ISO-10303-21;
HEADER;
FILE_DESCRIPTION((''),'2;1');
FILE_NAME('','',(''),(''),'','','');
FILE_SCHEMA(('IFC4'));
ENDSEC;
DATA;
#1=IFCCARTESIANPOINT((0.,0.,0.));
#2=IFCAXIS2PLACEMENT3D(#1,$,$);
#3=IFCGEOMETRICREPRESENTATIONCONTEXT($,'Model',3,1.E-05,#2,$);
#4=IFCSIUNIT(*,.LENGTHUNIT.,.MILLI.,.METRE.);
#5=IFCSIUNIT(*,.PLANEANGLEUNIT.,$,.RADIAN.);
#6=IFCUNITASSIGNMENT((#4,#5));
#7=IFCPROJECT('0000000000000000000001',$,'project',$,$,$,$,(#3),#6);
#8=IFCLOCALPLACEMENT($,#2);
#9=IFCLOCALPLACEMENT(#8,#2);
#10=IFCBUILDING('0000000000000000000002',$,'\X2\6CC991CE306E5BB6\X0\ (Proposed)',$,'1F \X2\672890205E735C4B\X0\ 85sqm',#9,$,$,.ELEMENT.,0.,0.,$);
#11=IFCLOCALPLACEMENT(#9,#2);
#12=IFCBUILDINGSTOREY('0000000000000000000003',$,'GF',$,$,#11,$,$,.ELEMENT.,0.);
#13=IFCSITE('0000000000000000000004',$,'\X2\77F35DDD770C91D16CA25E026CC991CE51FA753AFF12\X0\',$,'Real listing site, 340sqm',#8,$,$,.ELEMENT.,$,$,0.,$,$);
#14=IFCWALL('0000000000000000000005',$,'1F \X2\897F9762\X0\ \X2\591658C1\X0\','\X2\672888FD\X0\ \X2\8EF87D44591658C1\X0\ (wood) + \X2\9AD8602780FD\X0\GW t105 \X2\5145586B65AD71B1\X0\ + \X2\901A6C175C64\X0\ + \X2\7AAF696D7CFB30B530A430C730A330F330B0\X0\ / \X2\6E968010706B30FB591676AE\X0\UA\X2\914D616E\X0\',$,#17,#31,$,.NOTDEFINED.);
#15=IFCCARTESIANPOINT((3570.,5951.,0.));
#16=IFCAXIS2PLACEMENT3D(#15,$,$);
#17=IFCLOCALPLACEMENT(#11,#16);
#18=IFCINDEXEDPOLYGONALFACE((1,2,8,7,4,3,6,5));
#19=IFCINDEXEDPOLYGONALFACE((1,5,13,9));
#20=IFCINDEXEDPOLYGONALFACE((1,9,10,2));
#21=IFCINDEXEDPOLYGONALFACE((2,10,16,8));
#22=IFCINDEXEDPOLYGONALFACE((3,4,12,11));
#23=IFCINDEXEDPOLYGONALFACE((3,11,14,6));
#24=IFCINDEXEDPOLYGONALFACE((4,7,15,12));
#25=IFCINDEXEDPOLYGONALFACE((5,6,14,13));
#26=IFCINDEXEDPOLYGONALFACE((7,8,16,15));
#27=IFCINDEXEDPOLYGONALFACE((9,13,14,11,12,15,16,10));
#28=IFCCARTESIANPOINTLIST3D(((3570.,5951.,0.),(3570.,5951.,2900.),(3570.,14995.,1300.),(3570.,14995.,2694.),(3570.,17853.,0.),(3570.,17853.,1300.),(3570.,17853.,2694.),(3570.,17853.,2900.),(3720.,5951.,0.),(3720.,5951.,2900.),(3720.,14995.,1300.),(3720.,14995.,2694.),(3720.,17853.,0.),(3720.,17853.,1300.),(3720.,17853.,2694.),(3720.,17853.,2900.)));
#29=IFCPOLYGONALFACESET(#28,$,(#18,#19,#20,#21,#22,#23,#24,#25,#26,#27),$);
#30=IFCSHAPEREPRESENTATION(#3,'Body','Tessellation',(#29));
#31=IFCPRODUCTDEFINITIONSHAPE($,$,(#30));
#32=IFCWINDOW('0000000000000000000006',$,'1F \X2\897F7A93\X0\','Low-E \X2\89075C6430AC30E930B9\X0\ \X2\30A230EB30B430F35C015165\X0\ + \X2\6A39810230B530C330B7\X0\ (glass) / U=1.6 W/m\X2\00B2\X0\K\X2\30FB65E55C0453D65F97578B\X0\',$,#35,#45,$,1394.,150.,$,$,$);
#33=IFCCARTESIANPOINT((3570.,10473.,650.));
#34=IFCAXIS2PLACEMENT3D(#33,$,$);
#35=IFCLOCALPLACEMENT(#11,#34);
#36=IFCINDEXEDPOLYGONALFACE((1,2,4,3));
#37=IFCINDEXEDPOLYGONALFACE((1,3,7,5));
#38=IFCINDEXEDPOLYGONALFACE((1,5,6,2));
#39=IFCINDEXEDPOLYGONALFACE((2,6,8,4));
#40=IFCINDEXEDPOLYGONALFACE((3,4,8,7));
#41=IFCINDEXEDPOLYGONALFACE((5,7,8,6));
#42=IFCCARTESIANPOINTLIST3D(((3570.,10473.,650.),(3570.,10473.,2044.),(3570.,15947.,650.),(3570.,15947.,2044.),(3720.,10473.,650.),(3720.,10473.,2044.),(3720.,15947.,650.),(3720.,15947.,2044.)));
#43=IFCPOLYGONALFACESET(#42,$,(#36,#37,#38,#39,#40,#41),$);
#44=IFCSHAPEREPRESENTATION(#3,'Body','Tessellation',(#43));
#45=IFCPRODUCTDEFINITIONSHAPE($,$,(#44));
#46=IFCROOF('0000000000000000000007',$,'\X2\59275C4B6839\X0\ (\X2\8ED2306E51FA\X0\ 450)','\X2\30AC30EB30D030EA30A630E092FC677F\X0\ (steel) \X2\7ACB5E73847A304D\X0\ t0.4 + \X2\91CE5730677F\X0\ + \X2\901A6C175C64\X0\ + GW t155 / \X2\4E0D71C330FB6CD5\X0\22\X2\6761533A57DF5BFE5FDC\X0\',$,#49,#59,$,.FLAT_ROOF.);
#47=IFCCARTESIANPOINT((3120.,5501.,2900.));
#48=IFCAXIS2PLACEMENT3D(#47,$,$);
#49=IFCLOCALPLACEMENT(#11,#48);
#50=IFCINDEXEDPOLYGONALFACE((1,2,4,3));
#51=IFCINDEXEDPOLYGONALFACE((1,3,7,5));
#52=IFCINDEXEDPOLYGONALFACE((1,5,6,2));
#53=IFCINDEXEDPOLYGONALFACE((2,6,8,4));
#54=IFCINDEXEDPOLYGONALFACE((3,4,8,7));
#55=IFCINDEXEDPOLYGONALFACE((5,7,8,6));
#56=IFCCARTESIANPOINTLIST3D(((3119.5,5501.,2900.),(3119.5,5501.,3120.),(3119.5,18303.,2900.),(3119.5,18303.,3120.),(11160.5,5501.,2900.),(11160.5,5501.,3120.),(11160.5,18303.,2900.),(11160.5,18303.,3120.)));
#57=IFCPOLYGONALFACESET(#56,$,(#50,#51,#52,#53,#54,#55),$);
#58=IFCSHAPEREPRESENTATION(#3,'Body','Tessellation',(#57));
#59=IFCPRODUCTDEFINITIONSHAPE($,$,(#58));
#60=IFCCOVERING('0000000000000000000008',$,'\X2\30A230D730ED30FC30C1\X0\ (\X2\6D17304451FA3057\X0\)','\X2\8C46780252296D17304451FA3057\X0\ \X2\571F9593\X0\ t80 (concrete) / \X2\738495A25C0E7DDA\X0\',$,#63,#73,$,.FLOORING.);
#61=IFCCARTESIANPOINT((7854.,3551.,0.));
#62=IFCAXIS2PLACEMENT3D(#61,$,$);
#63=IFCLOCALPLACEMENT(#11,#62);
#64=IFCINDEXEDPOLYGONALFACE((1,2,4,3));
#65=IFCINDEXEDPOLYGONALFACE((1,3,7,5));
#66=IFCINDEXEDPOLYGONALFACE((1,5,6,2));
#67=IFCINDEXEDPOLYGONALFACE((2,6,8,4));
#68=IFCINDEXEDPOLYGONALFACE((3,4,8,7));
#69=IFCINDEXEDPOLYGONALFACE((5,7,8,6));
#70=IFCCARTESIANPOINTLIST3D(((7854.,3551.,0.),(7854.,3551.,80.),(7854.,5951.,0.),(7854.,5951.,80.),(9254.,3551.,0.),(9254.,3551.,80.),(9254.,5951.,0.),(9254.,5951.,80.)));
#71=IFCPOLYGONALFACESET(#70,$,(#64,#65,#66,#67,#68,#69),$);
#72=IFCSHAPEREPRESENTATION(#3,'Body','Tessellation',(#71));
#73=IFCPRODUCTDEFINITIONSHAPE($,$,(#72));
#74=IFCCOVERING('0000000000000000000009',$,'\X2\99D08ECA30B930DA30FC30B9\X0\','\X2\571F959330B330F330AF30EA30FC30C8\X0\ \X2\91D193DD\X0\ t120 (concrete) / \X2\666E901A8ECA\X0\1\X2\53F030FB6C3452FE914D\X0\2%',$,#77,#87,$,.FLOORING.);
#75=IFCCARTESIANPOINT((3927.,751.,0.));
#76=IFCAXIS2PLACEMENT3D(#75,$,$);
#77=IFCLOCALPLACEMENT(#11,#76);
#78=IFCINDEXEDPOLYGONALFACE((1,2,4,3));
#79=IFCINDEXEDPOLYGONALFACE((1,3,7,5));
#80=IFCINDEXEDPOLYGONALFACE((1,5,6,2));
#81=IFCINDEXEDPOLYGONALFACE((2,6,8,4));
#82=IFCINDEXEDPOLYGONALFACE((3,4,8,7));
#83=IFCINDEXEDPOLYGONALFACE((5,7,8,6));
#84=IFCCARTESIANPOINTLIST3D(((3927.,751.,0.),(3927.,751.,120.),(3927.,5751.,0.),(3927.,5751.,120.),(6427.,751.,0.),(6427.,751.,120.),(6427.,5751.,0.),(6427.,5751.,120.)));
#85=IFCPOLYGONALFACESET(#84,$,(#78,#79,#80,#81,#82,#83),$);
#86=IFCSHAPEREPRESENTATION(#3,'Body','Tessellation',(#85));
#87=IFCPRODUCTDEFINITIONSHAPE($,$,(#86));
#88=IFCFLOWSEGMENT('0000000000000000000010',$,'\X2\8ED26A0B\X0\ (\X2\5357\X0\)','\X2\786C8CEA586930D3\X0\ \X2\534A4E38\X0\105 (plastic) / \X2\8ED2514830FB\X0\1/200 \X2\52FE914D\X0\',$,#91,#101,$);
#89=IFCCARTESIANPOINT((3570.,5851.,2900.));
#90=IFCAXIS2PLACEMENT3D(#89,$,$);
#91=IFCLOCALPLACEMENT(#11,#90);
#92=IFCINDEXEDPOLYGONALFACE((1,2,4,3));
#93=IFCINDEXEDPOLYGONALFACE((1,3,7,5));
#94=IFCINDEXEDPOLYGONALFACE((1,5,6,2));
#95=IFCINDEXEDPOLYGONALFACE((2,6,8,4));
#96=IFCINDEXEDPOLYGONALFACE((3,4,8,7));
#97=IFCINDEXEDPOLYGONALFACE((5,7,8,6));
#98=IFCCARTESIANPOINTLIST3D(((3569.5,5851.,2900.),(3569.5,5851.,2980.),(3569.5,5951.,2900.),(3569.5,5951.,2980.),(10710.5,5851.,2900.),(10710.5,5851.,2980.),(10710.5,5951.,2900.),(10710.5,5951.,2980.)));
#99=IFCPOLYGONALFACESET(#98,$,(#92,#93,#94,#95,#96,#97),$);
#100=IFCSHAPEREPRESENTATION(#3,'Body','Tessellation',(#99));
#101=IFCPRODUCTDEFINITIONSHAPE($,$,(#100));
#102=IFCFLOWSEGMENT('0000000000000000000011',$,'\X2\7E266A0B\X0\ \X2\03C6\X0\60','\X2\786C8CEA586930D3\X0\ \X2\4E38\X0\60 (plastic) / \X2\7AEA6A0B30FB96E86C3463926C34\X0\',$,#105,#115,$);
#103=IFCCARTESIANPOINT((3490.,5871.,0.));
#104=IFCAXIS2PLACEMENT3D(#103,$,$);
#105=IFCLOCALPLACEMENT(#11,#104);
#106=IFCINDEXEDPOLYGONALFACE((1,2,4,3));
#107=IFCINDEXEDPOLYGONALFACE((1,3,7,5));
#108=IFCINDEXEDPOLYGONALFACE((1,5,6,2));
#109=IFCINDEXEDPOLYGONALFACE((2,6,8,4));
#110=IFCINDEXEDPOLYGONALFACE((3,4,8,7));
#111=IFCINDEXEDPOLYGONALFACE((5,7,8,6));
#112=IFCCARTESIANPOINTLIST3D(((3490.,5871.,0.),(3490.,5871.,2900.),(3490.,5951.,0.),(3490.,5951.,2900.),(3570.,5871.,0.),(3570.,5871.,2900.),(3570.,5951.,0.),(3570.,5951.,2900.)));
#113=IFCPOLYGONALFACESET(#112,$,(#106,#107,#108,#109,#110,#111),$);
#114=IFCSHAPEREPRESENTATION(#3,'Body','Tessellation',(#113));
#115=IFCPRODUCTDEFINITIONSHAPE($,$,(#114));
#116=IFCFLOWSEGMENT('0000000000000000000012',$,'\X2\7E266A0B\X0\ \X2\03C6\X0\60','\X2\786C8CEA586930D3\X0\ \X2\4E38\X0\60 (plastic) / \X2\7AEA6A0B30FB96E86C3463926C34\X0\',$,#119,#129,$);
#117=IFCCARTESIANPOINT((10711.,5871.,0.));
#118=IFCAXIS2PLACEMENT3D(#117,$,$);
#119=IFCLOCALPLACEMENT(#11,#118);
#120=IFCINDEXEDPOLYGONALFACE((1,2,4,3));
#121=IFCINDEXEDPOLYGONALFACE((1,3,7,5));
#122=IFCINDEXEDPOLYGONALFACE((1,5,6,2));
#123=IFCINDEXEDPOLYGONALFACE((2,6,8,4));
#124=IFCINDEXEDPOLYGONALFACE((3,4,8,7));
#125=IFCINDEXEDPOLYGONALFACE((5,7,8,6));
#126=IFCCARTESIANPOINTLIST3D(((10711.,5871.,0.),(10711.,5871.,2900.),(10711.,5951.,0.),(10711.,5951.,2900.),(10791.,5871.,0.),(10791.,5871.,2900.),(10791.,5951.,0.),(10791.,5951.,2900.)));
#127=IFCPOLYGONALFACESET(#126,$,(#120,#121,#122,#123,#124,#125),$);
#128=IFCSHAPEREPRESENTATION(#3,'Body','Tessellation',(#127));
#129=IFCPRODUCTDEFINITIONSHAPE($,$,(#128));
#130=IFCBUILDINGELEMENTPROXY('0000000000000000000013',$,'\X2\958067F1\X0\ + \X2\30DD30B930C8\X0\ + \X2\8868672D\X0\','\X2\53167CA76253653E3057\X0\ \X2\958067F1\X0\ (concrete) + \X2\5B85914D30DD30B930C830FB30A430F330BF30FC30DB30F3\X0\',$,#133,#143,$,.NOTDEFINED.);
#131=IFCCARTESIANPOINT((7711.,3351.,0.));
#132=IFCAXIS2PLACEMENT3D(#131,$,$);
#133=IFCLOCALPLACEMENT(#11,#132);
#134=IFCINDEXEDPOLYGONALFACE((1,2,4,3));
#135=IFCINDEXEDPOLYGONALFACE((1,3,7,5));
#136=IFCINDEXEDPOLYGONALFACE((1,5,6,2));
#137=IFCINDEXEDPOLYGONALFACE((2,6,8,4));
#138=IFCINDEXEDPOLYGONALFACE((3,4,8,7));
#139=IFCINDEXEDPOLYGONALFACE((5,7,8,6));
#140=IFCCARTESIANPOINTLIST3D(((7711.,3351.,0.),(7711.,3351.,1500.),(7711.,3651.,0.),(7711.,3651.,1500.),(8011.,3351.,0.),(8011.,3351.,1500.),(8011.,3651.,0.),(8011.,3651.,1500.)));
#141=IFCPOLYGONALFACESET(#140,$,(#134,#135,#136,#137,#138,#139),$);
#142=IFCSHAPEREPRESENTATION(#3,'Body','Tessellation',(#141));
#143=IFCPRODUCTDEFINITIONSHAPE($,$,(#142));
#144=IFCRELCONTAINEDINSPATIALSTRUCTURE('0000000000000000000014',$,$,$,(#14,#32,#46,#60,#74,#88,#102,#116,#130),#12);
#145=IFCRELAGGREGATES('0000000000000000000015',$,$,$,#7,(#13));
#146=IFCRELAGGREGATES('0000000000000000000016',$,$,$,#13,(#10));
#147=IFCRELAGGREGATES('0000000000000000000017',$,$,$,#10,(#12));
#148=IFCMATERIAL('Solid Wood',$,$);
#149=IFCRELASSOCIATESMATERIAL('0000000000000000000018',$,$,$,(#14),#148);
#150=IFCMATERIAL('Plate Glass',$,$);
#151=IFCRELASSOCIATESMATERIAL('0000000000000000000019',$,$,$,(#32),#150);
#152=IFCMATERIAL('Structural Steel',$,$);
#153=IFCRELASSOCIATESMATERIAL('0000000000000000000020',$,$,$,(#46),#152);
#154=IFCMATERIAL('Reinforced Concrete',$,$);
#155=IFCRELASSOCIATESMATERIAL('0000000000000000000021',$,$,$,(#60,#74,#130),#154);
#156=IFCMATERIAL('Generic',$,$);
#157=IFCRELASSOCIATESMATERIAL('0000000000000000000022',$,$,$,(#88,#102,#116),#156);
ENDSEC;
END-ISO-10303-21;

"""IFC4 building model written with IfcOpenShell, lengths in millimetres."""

from ifc_helpers import new_model, si_unit, frame, frame_2d, origin, place, context, project, spatial, rectangle, extrude, material, element, fill, save


model = new_model("IFC4")

# Units and contexts
model_context = context("Model", 3, precision=1e-05, world=origin())
ifc_project = project(units=[si_unit("LENGTHUNIT", "METRE", prefix="MILLI"), si_unit("PLANEANGLEUNIT", "RADIAN")], contexts=[model_context])

# Site, building, storey
site_placement = place(None, origin())
site = spatial("IfcSite", under=ifc_project, at=site_placement, Name="石川県金沢市泉野出町２", ObjectType="Real listing site, 340sqm", CompositionType="ELEMENT", RefElevation=0.0)
building_placement = place(site_placement, origin())
building = spatial("IfcBuilding", under=site, at=building_placement, Name="泉野の家 (Proposed)", ObjectType="1F 木造平屋 85sqm", CompositionType="ELEMENT", ElevationOfRefHeight=0.0, ElevationOfTerrain=0.0)
storey_placement = place(building_placement, origin())
storey = spatial("IfcBuildingStorey", under=building, at=storey_placement, Name="GF", CompositionType="ELEMENT", Elevation=0.0)

# Shared definitions
ifc_material_1 = material(Name="Solid Wood")

# Shared definitions
ifc_material_2 = material(Name="Reinforced Concrete")

# Shared definitions
ifc_material_3 = material(Name="Plate Glass")

# Wall, opening, window
wall_1_placement = place(storey_placement, frame((3570.0, 5951.0, 0.0)))
wall_1 = element("IfcWall", 1, at=wall_1_placement, inside=storey, material=ifc_material_1, Name="1F 西面 外壁", Description="木製 軸組外壁 (wood) + 高性能GW t105 充填断熱 + 通気層 + 窯業系サイディング / 準耐火・外皮UA配慮", PredefinedType="NOTDEFINED", context=model_context, shape_type="SweptSolid", body=[
    extrude(rectangle(XDim=150.0, YDim=11902.0, at=frame_2d((75.0, 5951.0))), frame((3570.0, 5951.0, 0.0)), (0.0, 0.0, 1.0), 2900.0),
])
opening_1_placement = place(storey_placement, frame((3570.0, 10473.0, 650.0)))
opening_1 = element("IfcOpeningElement", 2, at=opening_1_placement, cuts=wall_1, PredefinedType="NOTDEFINED", context=model_context, shape_type="SweptSolid", body=[
    extrude(rectangle(XDim=150.0, YDim=5474.0, at=frame_2d((75.0, 2737.0))), frame((3570.0, 10473.0, 650.0)), (0.0, 0.0, 1.0), 1394.0),
])
window_1_placement = place(storey_placement, frame((3570.0, 10473.0, 650.0)))
window_1 = element("IfcWindow", 3, at=window_1_placement, inside=storey, material=ifc_material_3, Name="1F 西窓", Description="Low-E 複層ガラス アルゴン封入 + 樹脂サッシ (glass) / U=1.6 W/m²K・日射取得型", OverallHeight=1394.0, OverallWidth=150.0, context=model_context, shape_type="SweptSolid", body=[
    extrude(rectangle(XDim=150.0, YDim=5474.0, at=frame_2d((75.0, 2737.0))), frame((3570.0, 10473.0, 650.0)), (0.0, 0.0, 1.0), 1394.0),
])
fill(opening_1, window_1)

# Roof
ifc_material_4 = material(Name="Structural Steel")
roof_placement = place(storey_placement, frame((3120.0, 5501.0, 2900.0)))
element("IfcRoof", 4, at=roof_placement, inside=storey, material=ifc_material_4, Name="大屋根 (軒の出 450)", Description="ガルバリウム鋼板 (steel) 立平葺き t0.4 + 野地板 + 通気層 + GW t155 / 不燃・法22条区域対応", PredefinedType="FLAT_ROOF", context=model_context, shape_type="SweptSolid", body=[
    extrude(rectangle(XDim=8041.0, YDim=12802.0, at=frame_2d((4020.0, 6401.0))), frame((3120.0, 5501.0, 2900.0)), (0.0, 0.0, 1.0), 220.0),
])

# Coverings
covering_1_placement = place(storey_placement, frame((7854.0, 3551.0, 0.0)))
element("IfcCovering", 5, at=covering_1_placement, inside=storey, material=ifc_material_2, Name="アプローチ (洗い出し)", Description="豆砂利洗い出し 土間 t80 (concrete) / 玄関導線", PredefinedType="FLOORING", context=model_context, shape_type="SweptSolid", body=[
    extrude(rectangle(XDim=1400.0, YDim=2400.0, at=frame_2d((700.0, 1200.0))), frame((7854.0, 3551.0, 0.0)), (0.0, 0.0, 1.0), 80.0),
])
covering_2_placement = place(storey_placement, frame((3927.0, 751.0, 0.0)))
element("IfcCovering", 6, at=covering_2_placement, inside=storey, material=ifc_material_2, Name="駐車スペース", Description="土間コンクリート 金鏝 t120 (concrete) / 普通車1台・水勾配2%", PredefinedType="FLOORING", context=model_context, shape_type="SweptSolid", body=[
    extrude(rectangle(XDim=2500.0, YDim=5000.0, at=frame_2d((1250.0, 2500.0))), frame((3927.0, 751.0, 0.0)), (0.0, 0.0, 1.0), 120.0),
])

# Flow segments
ifc_material_5 = material(Name="Generic")
flow_segment_1_placement = place(storey_placement, frame((3570.0, 5851.0, 2900.0)))
element("IfcFlowSegment", 7, at=flow_segment_1_placement, inside=storey, material=ifc_material_5, Name="軒樋 (南)", Description="硬質塩ビ 半丸105 (plastic) / 軒先・1/200 勾配", context=model_context, shape_type="SweptSolid", body=[
    extrude(rectangle(XDim=7141.0, YDim=100.0, at=frame_2d((3570.0, 50.0))), frame((3570.0, 5851.0, 2900.0)), (0.0, 0.0, 1.0), 80.0),
])
flow_segment_2_placement = place(storey_placement, frame((3490.0, 5871.0, 0.0)))
element("IfcFlowSegment", 8, at=flow_segment_2_placement, inside=storey, material=ifc_material_5, Name="縦樋 φ60", Description="硬質塩ビ 丸60 (plastic) / 竪樋・雨水排水", context=model_context, shape_type="SweptSolid", body=[
    extrude(rectangle(XDim=80.0, YDim=80.0, at=frame_2d((40.0, 40.0))), frame((3490.0, 5871.0, 0.0)), (0.0, 0.0, 1.0), 2900.0),
])
flow_segment_3_placement = place(storey_placement, frame((10711.0, 5871.0, 0.0)))
element("IfcFlowSegment", 9, at=flow_segment_3_placement, inside=storey, material=ifc_material_5, Name="縦樋 φ60", Description="硬質塩ビ 丸60 (plastic) / 竪樋・雨水排水", context=model_context, shape_type="SweptSolid", body=[
    extrude(rectangle(XDim=80.0, YDim=80.0, at=frame_2d((40.0, 40.0))), frame((10711.0, 5871.0, 0.0)), (0.0, 0.0, 1.0), 2900.0),
])

# Building element proxy
proxy_placement = place(storey_placement, frame((7711.0, 3351.0, 0.0)))
element("IfcBuildingElementProxy", 10, at=proxy_placement, inside=storey, material=ifc_material_2, Name="門柱 + ポスト + 表札", Description="化粧打放し 門柱 (concrete) + 宅配ポスト・インターホン", PredefinedType="NOTDEFINED", context=model_context, shape_type="SweptSolid", body=[
    extrude(rectangle(XDim=300.0, YDim=300.0, at=frame_2d((150.0, 150.0))), frame((7711.0, 3351.0, 0.0)), (0.0, 0.0, 1.0), 1500.0),
])

save(model, "model.ifc")
